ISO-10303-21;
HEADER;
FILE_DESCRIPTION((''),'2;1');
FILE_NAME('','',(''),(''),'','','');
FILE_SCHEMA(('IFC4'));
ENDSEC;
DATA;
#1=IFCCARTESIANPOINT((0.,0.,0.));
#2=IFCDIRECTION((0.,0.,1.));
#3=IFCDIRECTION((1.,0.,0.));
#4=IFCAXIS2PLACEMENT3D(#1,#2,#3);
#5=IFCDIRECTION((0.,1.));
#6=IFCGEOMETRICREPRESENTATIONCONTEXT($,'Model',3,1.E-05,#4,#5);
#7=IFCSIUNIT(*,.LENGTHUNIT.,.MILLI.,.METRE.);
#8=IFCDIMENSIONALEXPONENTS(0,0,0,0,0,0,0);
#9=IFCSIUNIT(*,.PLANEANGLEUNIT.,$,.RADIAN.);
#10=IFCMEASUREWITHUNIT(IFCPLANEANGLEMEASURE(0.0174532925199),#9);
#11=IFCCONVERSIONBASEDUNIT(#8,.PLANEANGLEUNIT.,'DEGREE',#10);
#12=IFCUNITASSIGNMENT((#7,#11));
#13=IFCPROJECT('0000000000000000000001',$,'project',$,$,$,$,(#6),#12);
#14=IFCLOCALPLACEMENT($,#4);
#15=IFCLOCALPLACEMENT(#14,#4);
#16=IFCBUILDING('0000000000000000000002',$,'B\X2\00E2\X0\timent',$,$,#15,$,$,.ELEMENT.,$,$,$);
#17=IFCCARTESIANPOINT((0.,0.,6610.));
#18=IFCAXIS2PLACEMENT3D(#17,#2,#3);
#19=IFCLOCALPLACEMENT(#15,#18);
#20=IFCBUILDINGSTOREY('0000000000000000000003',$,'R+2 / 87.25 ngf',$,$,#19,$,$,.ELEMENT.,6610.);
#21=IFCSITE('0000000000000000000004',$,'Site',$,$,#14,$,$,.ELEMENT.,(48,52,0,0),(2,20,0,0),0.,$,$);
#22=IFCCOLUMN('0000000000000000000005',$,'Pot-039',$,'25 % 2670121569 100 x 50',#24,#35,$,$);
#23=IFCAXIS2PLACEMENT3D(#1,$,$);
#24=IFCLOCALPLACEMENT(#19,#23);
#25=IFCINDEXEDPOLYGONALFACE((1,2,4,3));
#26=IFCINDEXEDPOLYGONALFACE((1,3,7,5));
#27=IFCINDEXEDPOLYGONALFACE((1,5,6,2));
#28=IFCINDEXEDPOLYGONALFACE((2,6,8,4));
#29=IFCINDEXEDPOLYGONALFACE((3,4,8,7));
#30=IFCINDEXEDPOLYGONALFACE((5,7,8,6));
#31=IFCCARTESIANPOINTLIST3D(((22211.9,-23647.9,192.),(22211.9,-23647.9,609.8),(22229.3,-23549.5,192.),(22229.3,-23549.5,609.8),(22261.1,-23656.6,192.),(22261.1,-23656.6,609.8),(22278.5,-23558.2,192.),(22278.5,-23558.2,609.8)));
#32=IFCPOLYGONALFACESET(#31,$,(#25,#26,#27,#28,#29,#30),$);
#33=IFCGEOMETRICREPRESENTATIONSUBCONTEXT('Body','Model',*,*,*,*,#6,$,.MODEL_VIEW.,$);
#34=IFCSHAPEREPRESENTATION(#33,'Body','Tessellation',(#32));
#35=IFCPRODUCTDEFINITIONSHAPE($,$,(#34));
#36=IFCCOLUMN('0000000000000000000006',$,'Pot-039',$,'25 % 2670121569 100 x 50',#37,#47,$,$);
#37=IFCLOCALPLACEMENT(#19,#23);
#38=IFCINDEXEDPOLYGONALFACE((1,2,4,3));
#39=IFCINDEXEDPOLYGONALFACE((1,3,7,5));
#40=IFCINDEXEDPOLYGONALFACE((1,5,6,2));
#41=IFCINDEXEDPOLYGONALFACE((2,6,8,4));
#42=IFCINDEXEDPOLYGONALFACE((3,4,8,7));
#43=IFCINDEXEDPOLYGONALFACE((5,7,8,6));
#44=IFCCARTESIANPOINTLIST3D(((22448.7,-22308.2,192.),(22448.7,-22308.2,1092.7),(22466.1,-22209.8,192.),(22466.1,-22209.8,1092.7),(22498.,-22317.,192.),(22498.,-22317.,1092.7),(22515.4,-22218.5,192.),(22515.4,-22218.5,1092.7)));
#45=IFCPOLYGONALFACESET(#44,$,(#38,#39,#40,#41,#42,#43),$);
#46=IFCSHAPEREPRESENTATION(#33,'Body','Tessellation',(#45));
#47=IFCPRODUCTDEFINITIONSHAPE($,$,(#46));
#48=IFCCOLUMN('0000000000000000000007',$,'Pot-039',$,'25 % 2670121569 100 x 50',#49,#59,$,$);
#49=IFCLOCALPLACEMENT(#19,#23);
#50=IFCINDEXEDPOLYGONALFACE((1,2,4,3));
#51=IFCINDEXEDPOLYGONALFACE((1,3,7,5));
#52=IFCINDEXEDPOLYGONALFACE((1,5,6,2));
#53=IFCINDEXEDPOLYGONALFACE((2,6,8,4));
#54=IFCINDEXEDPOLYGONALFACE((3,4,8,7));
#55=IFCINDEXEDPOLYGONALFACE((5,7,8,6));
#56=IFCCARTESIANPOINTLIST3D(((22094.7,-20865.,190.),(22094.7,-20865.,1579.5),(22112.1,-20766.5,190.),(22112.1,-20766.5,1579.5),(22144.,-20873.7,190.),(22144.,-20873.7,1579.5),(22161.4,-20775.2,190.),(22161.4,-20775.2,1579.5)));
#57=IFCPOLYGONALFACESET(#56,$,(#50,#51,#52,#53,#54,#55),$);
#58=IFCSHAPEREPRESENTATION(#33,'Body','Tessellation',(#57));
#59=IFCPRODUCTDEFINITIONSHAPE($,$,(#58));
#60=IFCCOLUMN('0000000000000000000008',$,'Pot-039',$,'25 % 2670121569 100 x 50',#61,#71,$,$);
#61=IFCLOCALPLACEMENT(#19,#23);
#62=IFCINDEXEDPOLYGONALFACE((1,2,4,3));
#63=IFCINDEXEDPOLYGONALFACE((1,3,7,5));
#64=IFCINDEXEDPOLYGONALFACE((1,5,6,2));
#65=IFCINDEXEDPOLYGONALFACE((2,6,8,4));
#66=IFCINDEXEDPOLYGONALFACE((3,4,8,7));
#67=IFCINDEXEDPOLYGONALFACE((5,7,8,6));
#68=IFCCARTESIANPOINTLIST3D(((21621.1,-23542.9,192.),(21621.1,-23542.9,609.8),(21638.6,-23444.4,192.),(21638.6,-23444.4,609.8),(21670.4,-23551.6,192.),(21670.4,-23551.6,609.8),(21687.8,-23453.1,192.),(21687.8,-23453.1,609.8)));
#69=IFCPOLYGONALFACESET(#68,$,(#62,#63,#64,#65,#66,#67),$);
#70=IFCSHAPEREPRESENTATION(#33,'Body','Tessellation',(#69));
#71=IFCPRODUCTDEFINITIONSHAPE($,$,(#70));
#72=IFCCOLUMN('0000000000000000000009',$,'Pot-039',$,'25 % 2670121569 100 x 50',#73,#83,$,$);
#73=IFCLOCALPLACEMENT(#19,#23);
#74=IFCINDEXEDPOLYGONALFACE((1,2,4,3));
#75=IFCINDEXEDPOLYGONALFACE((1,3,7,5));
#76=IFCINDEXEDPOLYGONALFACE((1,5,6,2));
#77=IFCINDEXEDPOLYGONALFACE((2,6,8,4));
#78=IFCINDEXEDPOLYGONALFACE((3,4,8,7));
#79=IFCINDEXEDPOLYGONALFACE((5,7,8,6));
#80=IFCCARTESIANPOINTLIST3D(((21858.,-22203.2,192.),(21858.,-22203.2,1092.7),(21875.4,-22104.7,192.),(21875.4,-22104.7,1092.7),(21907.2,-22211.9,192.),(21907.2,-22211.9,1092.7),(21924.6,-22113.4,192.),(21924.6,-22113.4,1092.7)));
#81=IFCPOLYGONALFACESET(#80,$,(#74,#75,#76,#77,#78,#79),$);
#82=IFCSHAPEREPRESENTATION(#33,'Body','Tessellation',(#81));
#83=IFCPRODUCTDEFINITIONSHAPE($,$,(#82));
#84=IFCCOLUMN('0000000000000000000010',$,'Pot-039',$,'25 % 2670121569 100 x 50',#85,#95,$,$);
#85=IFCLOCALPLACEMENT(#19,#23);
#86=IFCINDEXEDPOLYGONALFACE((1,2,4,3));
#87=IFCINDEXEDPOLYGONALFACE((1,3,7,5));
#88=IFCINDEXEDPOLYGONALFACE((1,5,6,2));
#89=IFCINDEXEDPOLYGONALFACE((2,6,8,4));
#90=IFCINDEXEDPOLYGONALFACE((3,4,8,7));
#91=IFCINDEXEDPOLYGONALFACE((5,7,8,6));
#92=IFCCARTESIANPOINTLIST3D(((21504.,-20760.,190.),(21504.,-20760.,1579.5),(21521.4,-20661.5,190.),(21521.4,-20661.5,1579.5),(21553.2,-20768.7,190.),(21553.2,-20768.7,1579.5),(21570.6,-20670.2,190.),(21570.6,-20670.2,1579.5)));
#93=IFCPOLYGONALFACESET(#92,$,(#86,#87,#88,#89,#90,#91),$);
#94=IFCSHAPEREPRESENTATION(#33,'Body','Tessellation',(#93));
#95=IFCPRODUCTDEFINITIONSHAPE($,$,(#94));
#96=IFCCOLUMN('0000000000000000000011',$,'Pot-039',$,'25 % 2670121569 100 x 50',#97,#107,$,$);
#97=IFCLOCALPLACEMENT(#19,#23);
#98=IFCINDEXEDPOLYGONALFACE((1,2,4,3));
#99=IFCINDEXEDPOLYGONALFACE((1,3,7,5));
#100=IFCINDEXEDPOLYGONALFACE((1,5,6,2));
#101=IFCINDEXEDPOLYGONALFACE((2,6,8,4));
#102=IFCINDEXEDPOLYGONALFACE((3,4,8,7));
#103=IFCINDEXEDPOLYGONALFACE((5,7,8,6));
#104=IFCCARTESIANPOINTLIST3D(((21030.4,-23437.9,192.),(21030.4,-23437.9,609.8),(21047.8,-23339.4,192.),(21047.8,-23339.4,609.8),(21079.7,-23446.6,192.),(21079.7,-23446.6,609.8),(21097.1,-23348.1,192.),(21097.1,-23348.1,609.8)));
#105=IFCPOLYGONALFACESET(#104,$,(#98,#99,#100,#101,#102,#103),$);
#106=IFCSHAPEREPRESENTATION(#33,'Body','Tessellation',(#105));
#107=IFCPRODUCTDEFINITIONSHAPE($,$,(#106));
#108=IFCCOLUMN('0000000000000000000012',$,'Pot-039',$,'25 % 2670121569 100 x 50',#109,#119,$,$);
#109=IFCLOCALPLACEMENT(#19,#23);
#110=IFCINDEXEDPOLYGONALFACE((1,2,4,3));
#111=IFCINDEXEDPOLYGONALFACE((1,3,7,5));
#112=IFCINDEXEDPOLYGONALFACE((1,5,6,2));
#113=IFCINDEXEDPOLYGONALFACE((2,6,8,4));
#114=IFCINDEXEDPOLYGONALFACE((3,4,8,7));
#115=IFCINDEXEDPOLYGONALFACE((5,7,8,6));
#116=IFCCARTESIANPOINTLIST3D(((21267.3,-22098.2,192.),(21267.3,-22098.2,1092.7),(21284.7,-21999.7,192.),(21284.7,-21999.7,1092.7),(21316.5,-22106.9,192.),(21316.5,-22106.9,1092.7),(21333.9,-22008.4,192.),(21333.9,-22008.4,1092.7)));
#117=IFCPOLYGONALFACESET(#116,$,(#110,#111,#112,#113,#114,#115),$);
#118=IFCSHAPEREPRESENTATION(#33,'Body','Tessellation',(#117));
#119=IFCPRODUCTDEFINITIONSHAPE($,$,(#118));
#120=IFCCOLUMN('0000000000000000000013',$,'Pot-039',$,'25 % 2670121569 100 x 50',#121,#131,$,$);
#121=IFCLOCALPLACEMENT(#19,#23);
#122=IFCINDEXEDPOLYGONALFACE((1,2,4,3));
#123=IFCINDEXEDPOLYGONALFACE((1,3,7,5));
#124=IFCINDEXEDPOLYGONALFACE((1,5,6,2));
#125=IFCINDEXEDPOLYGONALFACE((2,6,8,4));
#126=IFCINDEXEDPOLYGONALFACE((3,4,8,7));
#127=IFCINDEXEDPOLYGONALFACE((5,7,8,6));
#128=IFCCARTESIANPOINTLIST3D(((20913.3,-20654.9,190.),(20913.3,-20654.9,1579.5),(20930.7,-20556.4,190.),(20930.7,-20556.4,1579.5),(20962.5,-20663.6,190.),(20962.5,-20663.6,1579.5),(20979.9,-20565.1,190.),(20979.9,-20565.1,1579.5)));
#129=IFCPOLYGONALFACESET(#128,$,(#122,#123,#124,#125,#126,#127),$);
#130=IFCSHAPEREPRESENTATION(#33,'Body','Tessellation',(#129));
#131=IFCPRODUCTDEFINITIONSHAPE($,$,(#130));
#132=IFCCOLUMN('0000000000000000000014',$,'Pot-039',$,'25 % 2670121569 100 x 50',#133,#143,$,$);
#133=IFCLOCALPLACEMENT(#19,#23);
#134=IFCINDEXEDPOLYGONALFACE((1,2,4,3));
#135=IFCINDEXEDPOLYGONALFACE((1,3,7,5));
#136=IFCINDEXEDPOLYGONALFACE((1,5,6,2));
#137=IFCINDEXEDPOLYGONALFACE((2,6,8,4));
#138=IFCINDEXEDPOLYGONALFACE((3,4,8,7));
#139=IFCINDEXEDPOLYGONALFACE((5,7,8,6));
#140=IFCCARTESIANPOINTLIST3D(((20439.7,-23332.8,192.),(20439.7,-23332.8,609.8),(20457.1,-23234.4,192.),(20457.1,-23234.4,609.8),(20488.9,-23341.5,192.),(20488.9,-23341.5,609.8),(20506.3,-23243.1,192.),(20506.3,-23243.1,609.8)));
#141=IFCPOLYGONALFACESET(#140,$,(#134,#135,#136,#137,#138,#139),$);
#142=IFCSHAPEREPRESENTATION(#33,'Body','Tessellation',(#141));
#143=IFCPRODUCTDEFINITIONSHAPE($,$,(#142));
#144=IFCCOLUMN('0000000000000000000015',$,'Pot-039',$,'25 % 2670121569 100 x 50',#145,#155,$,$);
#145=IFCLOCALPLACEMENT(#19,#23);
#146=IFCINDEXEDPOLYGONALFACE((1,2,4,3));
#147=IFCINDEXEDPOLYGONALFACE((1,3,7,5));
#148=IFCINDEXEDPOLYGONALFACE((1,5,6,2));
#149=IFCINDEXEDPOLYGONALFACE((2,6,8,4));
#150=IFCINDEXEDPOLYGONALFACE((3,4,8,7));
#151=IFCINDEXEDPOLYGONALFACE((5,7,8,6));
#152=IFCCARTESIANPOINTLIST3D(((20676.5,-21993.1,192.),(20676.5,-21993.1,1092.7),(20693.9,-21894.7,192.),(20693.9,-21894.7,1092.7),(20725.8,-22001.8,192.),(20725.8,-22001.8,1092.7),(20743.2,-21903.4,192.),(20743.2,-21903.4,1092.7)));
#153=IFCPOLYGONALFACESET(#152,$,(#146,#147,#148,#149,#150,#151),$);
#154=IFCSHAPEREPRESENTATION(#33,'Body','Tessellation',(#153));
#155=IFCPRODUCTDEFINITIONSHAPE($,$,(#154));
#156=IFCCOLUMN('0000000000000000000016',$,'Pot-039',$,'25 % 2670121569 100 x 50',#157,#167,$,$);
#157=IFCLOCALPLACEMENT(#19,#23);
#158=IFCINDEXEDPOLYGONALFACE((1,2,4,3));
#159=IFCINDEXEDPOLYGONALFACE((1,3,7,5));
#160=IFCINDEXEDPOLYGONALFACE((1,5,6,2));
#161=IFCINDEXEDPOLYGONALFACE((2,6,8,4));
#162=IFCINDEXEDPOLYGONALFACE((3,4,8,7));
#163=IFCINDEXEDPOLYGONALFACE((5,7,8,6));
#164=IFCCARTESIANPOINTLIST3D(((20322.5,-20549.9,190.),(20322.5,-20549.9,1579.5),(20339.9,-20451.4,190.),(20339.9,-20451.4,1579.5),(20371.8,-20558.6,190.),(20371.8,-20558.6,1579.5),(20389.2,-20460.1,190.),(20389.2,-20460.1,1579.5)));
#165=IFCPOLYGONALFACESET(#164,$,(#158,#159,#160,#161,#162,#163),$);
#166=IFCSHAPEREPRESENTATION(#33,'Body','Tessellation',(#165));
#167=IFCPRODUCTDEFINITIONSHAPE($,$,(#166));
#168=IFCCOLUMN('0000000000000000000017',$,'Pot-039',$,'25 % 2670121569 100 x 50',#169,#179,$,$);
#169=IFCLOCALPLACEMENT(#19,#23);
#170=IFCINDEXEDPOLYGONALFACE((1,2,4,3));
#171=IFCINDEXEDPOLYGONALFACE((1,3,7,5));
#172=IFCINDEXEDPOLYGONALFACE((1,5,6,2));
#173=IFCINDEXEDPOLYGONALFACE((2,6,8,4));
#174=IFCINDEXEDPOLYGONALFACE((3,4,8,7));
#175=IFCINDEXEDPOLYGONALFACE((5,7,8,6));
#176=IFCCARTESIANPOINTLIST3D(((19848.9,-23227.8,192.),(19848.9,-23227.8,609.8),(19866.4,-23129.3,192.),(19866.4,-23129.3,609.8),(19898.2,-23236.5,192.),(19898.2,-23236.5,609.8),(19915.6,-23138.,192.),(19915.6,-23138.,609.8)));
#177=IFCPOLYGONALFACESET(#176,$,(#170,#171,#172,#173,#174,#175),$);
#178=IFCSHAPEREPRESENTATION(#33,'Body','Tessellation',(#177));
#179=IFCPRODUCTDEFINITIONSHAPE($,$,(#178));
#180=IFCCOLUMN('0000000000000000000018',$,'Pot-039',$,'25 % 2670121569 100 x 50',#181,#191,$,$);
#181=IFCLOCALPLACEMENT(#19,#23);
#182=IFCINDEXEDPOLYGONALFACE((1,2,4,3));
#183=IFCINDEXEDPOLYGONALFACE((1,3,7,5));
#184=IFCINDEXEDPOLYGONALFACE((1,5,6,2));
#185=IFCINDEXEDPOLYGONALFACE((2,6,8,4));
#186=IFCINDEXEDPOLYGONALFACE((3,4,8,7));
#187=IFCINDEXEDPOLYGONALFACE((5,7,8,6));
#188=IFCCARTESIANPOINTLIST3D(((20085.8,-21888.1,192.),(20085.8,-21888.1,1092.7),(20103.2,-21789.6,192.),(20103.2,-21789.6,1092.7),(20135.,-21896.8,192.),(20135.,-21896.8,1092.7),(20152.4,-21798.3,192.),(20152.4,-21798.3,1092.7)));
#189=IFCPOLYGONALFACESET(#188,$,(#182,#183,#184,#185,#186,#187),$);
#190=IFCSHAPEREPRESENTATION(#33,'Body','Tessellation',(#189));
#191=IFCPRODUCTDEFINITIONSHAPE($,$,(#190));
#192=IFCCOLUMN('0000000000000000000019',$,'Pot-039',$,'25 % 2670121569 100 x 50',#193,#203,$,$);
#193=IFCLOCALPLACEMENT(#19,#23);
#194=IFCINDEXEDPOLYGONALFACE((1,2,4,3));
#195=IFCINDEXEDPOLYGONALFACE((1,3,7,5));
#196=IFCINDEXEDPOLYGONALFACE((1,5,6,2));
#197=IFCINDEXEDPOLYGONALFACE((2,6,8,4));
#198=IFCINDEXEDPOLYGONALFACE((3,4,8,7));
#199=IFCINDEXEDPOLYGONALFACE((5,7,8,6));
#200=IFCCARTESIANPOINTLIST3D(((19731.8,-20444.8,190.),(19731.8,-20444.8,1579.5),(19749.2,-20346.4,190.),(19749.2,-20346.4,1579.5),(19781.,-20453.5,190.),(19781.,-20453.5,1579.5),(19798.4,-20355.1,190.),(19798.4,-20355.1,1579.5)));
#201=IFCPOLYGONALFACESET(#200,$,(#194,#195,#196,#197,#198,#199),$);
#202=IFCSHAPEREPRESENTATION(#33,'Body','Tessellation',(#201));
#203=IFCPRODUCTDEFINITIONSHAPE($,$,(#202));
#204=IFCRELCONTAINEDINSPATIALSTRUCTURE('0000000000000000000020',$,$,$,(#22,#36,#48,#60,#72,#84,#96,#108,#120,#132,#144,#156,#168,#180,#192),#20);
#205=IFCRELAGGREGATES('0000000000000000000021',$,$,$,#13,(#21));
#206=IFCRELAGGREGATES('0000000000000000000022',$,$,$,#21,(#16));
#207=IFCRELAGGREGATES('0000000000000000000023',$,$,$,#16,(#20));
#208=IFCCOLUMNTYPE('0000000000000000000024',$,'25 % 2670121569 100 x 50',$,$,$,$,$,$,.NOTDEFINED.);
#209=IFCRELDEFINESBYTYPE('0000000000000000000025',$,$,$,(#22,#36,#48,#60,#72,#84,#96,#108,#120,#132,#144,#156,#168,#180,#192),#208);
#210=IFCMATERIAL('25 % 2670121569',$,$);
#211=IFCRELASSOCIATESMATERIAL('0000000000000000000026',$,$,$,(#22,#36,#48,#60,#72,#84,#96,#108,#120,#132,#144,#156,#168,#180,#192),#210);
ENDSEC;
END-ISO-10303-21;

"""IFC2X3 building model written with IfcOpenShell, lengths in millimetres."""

from ifc_helpers import new_model, entity, si_unit, converted_unit, direction, frame, origin_with_axes, origin_2d_with_axis, place, context, subcontext, project, spatial, rectangle, extrude, material, type_object, element, save


model = new_model("IFC2X3")

# Units and contexts
model_context = context("Model", 3, precision=1e-05, world=origin_with_axes(), true_north=direction((0.0, 1.0)))
body_context = subcontext(model_context, "Body", "Model", "MODEL_VIEW")
ifc_project = project(units=[si_unit("LENGTHUNIT", "METRE", prefix="MILLI"), converted_unit("PLANEANGLEUNIT", "DEGREE", entity("IfcPlaneAngleMeasure", 0.0174532925199), si_unit("PLANEANGLEUNIT", "RADIAN"), dimensions=[0, 0, 0, 0, 0, 0, 0])], contexts=[model_context])

# Site, building, storey
site_placement = place(None, origin_with_axes())
site = spatial("IfcSite", under=ifc_project, at=site_placement, Name="Site", CompositionType="ELEMENT", RefLatitude=(48, 52, 0, 0), RefLongitude=(2, 20, 0, 0), RefElevation=0.0)
building_placement = place(site_placement, origin_with_axes())
building = spatial("IfcBuilding", under=site, at=building_placement, Name="Bâtiment", CompositionType="ELEMENT")
storey_placement = place(building_placement, frame((0.0, 0.0, 6610.0), z_axis=(0.0, 0.0, 1.0), x_axis=(1.0, 0.0, 0.0)))
storey = spatial("IfcBuildingStorey", under=building, at=storey_placement, Name="R+2 / 87.25 ngf", CompositionType="ELEMENT", Elevation=6610.0)

# Columns
ifc_material_1 = material(Name="25 % 2670121569")
column_type = type_object("IfcColumnType", Name="25 % 2670121569 100 x 50", PredefinedType="NOTDEFINED")
column_1_placement = place(storey_placement, frame((22245.2, -23603.1, 192.0), z_axis=(0.0, 0.0, 1.0), x_axis=(0.17408, 0.984731, 0.0)))
element("IfcColumn", 1, at=column_1_placement, inside=storey, type_object=column_type, material=ifc_material_1, Name="Pot-039", ObjectType="25 % 2670121569 100 x 50", context=body_context, shape_type="SweptSolid", body=[
    extrude(rectangle(XDim=100.0, YDim=50.0, at=origin_2d_with_axis()), origin_with_axes(), (0.0, 0.0, 1.0), 417.8),
])
column_2_placement = place(storey_placement, frame((22482.1, -22263.4, 192.0), z_axis=(0.0, 0.0, 1.0), x_axis=(0.17408, 0.984731, 0.0)))
element("IfcColumn", 2, at=column_2_placement, inside=storey, type_object=column_type, material=ifc_material_1, Name="Pot-039", ObjectType="25 % 2670121569 100 x 50", context=body_context, shape_type="SweptSolid", body=[
    extrude(rectangle(XDim=100.0, YDim=50.0, at=origin_2d_with_axis()), origin_with_axes(), (0.0, 0.0, 1.0), 900.7),
])
column_3_placement = place(storey_placement, frame((22128.0, -20820.1, 190.0), z_axis=(0.0, 0.0, 1.0), x_axis=(0.17408, 0.984731, 0.0)))
element("IfcColumn", 3, at=column_3_placement, inside=storey, type_object=column_type, material=ifc_material_1, Name="Pot-039", ObjectType="25 % 2670121569 100 x 50", context=body_context, shape_type="SweptSolid", body=[
    extrude(rectangle(XDim=100.0, YDim=50.0, at=origin_2d_with_axis()), origin_with_axes(), (0.0, 0.0, 1.0), 1389.5),
])
column_4_placement = place(storey_placement, frame((21654.5, -23498.0, 192.0), z_axis=(0.0, 0.0, 1.0), x_axis=(0.17408, 0.984731, 0.0)))
element("IfcColumn", 4, at=column_4_placement, inside=storey, type_object=column_type, material=ifc_material_1, Name="Pot-039", ObjectType="25 % 2670121569 100 x 50", context=body_context, shape_type="SweptSolid", body=[
    extrude(rectangle(XDim=100.0, YDim=50.0, at=origin_2d_with_axis()), origin_with_axes(), (0.0, 0.0, 1.0), 417.8),
])
column_5_placement = place(storey_placement, frame((21891.3, -22158.3, 192.0), z_axis=(0.0, 0.0, 1.0), x_axis=(0.17408, 0.984731, 0.0)))
element("IfcColumn", 5, at=column_5_placement, inside=storey, type_object=column_type, material=ifc_material_1, Name="Pot-039", ObjectType="25 % 2670121569 100 x 50", context=body_context, shape_type="SweptSolid", body=[
    extrude(rectangle(XDim=100.0, YDim=50.0, at=origin_2d_with_axis()), origin_with_axes(), (0.0, 0.0, 1.0), 900.7),
])
column_6_placement = place(storey_placement, frame((21537.3, -20715.1, 190.0), z_axis=(0.0, 0.0, 1.0), x_axis=(0.17408, 0.984731, 0.0)))
element("IfcColumn", 6, at=column_6_placement, inside=storey, type_object=column_type, material=ifc_material_1, Name="Pot-039", ObjectType="25 % 2670121569 100 x 50", context=body_context, shape_type="SweptSolid", body=[
    extrude(rectangle(XDim=100.0, YDim=50.0, at=origin_2d_with_axis()), origin_with_axes(), (0.0, 0.0, 1.0), 1389.5),
])
column_7_placement = place(storey_placement, frame((21063.7, -23393.0, 192.0), z_axis=(0.0, 0.0, 1.0), x_axis=(0.17408, 0.984731, 0.0)))
element("IfcColumn", 7, at=column_7_placement, inside=storey, type_object=column_type, material=ifc_material_1, Name="Pot-039", ObjectType="25 % 2670121569 100 x 50", context=body_context, shape_type="SweptSolid", body=[
    extrude(rectangle(XDim=100.0, YDim=50.0, at=origin_2d_with_axis()), origin_with_axes(), (0.0, 0.0, 1.0), 417.8),
])
column_8_placement = place(storey_placement, frame((21300.6, -22053.3, 192.0), z_axis=(0.0, 0.0, 1.0), x_axis=(0.17408, 0.984731, 0.0)))
element("IfcColumn", 8, at=column_8_placement, inside=storey, type_object=column_type, material=ifc_material_1, Name="Pot-039", ObjectType="25 % 2670121569 100 x 50", context=body_context, shape_type="SweptSolid", body=[
    extrude(rectangle(XDim=100.0, YDim=50.0, at=origin_2d_with_axis()), origin_with_axes(), (0.0, 0.0, 1.0), 900.7),
])
column_9_placement = place(storey_placement, frame((20946.6, -20610.0, 190.0), z_axis=(0.0, 0.0, 1.0), x_axis=(0.17408, 0.984731, 0.0)))
element("IfcColumn", 9, at=column_9_placement, inside=storey, type_object=column_type, material=ifc_material_1, Name="Pot-039", ObjectType="25 % 2670121569 100 x 50", context=body_context, shape_type="SweptSolid", body=[
    extrude(rectangle(XDim=100.0, YDim=50.0, at=origin_2d_with_axis()), origin_with_axes(), (0.0, 0.0, 1.0), 1389.5),
])
column_10_placement = place(storey_placement, frame((20473.0, -23287.9, 192.0), z_axis=(0.0, 0.0, 1.0), x_axis=(0.17408, 0.984731, 0.0)))
element("IfcColumn", 10, at=column_10_placement, inside=storey, type_object=column_type, material=ifc_material_1, Name="Pot-039", ObjectType="25 % 2670121569 100 x 50", context=body_context, shape_type="SweptSolid", body=[
    extrude(rectangle(XDim=100.0, YDim=50.0, at=origin_2d_with_axis()), origin_with_axes(), (0.0, 0.0, 1.0), 417.8),
])
column_11_placement = place(storey_placement, frame((20709.9, -21948.3, 192.0), z_axis=(0.0, 0.0, 1.0), x_axis=(0.17408, 0.984731, 0.0)))
element("IfcColumn", 11, at=column_11_placement, inside=storey, type_object=column_type, material=ifc_material_1, Name="Pot-039", ObjectType="25 % 2670121569 100 x 50", context=body_context, shape_type="SweptSolid", body=[
    extrude(rectangle(XDim=100.0, YDim=50.0, at=origin_2d_with_axis()), origin_with_axes(), (0.0, 0.0, 1.0), 900.7),
])
column_12_placement = place(storey_placement, frame((20355.8, -20505.0, 190.0), z_axis=(0.0, 0.0, 1.0), x_axis=(0.17408, 0.984731, 0.0)))
element("IfcColumn", 12, at=column_12_placement, inside=storey, type_object=column_type, material=ifc_material_1, Name="Pot-039", ObjectType="25 % 2670121569 100 x 50", context=body_context, shape_type="SweptSolid", body=[
    extrude(rectangle(XDim=100.0, YDim=50.0, at=origin_2d_with_axis()), origin_with_axes(), (0.0, 0.0, 1.0), 1389.5),
])
column_13_placement = place(storey_placement, frame((19882.3, -23182.9, 192.0), z_axis=(0.0, 0.0, 1.0), x_axis=(0.17408, 0.984731, 0.0)))
element("IfcColumn", 13, at=column_13_placement, inside=storey, type_object=column_type, material=ifc_material_1, Name="Pot-039", ObjectType="25 % 2670121569 100 x 50", context=body_context, shape_type="SweptSolid", body=[
    extrude(rectangle(XDim=100.0, YDim=50.0, at=origin_2d_with_axis()), origin_with_axes(), (0.0, 0.0, 1.0), 417.8),
])
column_14_placement = place(storey_placement, frame((20119.1, -21843.2, 192.0), z_axis=(0.0, 0.0, 1.0), x_axis=(0.17408, 0.984731, 0.0)))
element("IfcColumn", 14, at=column_14_placement, inside=storey, type_object=column_type, material=ifc_material_1, Name="Pot-039", ObjectType="25 % 2670121569 100 x 50", context=body_context, shape_type="SweptSolid", body=[
    extrude(rectangle(XDim=100.0, YDim=50.0, at=origin_2d_with_axis()), origin_with_axes(), (0.0, 0.0, 1.0), 900.7),
])
column_15_placement = place(storey_placement, frame((19765.1, -20400.0, 190.0), z_axis=(0.0, 0.0, 1.0), x_axis=(0.17408, 0.984731, 0.0)))
element("IfcColumn", 15, at=column_15_placement, inside=storey, type_object=column_type, material=ifc_material_1, Name="Pot-039", ObjectType="25 % 2670121569 100 x 50", context=body_context, shape_type="SweptSolid", body=[
    extrude(rectangle(XDim=100.0, YDim=50.0, at=origin_2d_with_axis()), origin_with_axes(), (0.0, 0.0, 1.0), 1389.5),
])

save(model, "model.ifc")
